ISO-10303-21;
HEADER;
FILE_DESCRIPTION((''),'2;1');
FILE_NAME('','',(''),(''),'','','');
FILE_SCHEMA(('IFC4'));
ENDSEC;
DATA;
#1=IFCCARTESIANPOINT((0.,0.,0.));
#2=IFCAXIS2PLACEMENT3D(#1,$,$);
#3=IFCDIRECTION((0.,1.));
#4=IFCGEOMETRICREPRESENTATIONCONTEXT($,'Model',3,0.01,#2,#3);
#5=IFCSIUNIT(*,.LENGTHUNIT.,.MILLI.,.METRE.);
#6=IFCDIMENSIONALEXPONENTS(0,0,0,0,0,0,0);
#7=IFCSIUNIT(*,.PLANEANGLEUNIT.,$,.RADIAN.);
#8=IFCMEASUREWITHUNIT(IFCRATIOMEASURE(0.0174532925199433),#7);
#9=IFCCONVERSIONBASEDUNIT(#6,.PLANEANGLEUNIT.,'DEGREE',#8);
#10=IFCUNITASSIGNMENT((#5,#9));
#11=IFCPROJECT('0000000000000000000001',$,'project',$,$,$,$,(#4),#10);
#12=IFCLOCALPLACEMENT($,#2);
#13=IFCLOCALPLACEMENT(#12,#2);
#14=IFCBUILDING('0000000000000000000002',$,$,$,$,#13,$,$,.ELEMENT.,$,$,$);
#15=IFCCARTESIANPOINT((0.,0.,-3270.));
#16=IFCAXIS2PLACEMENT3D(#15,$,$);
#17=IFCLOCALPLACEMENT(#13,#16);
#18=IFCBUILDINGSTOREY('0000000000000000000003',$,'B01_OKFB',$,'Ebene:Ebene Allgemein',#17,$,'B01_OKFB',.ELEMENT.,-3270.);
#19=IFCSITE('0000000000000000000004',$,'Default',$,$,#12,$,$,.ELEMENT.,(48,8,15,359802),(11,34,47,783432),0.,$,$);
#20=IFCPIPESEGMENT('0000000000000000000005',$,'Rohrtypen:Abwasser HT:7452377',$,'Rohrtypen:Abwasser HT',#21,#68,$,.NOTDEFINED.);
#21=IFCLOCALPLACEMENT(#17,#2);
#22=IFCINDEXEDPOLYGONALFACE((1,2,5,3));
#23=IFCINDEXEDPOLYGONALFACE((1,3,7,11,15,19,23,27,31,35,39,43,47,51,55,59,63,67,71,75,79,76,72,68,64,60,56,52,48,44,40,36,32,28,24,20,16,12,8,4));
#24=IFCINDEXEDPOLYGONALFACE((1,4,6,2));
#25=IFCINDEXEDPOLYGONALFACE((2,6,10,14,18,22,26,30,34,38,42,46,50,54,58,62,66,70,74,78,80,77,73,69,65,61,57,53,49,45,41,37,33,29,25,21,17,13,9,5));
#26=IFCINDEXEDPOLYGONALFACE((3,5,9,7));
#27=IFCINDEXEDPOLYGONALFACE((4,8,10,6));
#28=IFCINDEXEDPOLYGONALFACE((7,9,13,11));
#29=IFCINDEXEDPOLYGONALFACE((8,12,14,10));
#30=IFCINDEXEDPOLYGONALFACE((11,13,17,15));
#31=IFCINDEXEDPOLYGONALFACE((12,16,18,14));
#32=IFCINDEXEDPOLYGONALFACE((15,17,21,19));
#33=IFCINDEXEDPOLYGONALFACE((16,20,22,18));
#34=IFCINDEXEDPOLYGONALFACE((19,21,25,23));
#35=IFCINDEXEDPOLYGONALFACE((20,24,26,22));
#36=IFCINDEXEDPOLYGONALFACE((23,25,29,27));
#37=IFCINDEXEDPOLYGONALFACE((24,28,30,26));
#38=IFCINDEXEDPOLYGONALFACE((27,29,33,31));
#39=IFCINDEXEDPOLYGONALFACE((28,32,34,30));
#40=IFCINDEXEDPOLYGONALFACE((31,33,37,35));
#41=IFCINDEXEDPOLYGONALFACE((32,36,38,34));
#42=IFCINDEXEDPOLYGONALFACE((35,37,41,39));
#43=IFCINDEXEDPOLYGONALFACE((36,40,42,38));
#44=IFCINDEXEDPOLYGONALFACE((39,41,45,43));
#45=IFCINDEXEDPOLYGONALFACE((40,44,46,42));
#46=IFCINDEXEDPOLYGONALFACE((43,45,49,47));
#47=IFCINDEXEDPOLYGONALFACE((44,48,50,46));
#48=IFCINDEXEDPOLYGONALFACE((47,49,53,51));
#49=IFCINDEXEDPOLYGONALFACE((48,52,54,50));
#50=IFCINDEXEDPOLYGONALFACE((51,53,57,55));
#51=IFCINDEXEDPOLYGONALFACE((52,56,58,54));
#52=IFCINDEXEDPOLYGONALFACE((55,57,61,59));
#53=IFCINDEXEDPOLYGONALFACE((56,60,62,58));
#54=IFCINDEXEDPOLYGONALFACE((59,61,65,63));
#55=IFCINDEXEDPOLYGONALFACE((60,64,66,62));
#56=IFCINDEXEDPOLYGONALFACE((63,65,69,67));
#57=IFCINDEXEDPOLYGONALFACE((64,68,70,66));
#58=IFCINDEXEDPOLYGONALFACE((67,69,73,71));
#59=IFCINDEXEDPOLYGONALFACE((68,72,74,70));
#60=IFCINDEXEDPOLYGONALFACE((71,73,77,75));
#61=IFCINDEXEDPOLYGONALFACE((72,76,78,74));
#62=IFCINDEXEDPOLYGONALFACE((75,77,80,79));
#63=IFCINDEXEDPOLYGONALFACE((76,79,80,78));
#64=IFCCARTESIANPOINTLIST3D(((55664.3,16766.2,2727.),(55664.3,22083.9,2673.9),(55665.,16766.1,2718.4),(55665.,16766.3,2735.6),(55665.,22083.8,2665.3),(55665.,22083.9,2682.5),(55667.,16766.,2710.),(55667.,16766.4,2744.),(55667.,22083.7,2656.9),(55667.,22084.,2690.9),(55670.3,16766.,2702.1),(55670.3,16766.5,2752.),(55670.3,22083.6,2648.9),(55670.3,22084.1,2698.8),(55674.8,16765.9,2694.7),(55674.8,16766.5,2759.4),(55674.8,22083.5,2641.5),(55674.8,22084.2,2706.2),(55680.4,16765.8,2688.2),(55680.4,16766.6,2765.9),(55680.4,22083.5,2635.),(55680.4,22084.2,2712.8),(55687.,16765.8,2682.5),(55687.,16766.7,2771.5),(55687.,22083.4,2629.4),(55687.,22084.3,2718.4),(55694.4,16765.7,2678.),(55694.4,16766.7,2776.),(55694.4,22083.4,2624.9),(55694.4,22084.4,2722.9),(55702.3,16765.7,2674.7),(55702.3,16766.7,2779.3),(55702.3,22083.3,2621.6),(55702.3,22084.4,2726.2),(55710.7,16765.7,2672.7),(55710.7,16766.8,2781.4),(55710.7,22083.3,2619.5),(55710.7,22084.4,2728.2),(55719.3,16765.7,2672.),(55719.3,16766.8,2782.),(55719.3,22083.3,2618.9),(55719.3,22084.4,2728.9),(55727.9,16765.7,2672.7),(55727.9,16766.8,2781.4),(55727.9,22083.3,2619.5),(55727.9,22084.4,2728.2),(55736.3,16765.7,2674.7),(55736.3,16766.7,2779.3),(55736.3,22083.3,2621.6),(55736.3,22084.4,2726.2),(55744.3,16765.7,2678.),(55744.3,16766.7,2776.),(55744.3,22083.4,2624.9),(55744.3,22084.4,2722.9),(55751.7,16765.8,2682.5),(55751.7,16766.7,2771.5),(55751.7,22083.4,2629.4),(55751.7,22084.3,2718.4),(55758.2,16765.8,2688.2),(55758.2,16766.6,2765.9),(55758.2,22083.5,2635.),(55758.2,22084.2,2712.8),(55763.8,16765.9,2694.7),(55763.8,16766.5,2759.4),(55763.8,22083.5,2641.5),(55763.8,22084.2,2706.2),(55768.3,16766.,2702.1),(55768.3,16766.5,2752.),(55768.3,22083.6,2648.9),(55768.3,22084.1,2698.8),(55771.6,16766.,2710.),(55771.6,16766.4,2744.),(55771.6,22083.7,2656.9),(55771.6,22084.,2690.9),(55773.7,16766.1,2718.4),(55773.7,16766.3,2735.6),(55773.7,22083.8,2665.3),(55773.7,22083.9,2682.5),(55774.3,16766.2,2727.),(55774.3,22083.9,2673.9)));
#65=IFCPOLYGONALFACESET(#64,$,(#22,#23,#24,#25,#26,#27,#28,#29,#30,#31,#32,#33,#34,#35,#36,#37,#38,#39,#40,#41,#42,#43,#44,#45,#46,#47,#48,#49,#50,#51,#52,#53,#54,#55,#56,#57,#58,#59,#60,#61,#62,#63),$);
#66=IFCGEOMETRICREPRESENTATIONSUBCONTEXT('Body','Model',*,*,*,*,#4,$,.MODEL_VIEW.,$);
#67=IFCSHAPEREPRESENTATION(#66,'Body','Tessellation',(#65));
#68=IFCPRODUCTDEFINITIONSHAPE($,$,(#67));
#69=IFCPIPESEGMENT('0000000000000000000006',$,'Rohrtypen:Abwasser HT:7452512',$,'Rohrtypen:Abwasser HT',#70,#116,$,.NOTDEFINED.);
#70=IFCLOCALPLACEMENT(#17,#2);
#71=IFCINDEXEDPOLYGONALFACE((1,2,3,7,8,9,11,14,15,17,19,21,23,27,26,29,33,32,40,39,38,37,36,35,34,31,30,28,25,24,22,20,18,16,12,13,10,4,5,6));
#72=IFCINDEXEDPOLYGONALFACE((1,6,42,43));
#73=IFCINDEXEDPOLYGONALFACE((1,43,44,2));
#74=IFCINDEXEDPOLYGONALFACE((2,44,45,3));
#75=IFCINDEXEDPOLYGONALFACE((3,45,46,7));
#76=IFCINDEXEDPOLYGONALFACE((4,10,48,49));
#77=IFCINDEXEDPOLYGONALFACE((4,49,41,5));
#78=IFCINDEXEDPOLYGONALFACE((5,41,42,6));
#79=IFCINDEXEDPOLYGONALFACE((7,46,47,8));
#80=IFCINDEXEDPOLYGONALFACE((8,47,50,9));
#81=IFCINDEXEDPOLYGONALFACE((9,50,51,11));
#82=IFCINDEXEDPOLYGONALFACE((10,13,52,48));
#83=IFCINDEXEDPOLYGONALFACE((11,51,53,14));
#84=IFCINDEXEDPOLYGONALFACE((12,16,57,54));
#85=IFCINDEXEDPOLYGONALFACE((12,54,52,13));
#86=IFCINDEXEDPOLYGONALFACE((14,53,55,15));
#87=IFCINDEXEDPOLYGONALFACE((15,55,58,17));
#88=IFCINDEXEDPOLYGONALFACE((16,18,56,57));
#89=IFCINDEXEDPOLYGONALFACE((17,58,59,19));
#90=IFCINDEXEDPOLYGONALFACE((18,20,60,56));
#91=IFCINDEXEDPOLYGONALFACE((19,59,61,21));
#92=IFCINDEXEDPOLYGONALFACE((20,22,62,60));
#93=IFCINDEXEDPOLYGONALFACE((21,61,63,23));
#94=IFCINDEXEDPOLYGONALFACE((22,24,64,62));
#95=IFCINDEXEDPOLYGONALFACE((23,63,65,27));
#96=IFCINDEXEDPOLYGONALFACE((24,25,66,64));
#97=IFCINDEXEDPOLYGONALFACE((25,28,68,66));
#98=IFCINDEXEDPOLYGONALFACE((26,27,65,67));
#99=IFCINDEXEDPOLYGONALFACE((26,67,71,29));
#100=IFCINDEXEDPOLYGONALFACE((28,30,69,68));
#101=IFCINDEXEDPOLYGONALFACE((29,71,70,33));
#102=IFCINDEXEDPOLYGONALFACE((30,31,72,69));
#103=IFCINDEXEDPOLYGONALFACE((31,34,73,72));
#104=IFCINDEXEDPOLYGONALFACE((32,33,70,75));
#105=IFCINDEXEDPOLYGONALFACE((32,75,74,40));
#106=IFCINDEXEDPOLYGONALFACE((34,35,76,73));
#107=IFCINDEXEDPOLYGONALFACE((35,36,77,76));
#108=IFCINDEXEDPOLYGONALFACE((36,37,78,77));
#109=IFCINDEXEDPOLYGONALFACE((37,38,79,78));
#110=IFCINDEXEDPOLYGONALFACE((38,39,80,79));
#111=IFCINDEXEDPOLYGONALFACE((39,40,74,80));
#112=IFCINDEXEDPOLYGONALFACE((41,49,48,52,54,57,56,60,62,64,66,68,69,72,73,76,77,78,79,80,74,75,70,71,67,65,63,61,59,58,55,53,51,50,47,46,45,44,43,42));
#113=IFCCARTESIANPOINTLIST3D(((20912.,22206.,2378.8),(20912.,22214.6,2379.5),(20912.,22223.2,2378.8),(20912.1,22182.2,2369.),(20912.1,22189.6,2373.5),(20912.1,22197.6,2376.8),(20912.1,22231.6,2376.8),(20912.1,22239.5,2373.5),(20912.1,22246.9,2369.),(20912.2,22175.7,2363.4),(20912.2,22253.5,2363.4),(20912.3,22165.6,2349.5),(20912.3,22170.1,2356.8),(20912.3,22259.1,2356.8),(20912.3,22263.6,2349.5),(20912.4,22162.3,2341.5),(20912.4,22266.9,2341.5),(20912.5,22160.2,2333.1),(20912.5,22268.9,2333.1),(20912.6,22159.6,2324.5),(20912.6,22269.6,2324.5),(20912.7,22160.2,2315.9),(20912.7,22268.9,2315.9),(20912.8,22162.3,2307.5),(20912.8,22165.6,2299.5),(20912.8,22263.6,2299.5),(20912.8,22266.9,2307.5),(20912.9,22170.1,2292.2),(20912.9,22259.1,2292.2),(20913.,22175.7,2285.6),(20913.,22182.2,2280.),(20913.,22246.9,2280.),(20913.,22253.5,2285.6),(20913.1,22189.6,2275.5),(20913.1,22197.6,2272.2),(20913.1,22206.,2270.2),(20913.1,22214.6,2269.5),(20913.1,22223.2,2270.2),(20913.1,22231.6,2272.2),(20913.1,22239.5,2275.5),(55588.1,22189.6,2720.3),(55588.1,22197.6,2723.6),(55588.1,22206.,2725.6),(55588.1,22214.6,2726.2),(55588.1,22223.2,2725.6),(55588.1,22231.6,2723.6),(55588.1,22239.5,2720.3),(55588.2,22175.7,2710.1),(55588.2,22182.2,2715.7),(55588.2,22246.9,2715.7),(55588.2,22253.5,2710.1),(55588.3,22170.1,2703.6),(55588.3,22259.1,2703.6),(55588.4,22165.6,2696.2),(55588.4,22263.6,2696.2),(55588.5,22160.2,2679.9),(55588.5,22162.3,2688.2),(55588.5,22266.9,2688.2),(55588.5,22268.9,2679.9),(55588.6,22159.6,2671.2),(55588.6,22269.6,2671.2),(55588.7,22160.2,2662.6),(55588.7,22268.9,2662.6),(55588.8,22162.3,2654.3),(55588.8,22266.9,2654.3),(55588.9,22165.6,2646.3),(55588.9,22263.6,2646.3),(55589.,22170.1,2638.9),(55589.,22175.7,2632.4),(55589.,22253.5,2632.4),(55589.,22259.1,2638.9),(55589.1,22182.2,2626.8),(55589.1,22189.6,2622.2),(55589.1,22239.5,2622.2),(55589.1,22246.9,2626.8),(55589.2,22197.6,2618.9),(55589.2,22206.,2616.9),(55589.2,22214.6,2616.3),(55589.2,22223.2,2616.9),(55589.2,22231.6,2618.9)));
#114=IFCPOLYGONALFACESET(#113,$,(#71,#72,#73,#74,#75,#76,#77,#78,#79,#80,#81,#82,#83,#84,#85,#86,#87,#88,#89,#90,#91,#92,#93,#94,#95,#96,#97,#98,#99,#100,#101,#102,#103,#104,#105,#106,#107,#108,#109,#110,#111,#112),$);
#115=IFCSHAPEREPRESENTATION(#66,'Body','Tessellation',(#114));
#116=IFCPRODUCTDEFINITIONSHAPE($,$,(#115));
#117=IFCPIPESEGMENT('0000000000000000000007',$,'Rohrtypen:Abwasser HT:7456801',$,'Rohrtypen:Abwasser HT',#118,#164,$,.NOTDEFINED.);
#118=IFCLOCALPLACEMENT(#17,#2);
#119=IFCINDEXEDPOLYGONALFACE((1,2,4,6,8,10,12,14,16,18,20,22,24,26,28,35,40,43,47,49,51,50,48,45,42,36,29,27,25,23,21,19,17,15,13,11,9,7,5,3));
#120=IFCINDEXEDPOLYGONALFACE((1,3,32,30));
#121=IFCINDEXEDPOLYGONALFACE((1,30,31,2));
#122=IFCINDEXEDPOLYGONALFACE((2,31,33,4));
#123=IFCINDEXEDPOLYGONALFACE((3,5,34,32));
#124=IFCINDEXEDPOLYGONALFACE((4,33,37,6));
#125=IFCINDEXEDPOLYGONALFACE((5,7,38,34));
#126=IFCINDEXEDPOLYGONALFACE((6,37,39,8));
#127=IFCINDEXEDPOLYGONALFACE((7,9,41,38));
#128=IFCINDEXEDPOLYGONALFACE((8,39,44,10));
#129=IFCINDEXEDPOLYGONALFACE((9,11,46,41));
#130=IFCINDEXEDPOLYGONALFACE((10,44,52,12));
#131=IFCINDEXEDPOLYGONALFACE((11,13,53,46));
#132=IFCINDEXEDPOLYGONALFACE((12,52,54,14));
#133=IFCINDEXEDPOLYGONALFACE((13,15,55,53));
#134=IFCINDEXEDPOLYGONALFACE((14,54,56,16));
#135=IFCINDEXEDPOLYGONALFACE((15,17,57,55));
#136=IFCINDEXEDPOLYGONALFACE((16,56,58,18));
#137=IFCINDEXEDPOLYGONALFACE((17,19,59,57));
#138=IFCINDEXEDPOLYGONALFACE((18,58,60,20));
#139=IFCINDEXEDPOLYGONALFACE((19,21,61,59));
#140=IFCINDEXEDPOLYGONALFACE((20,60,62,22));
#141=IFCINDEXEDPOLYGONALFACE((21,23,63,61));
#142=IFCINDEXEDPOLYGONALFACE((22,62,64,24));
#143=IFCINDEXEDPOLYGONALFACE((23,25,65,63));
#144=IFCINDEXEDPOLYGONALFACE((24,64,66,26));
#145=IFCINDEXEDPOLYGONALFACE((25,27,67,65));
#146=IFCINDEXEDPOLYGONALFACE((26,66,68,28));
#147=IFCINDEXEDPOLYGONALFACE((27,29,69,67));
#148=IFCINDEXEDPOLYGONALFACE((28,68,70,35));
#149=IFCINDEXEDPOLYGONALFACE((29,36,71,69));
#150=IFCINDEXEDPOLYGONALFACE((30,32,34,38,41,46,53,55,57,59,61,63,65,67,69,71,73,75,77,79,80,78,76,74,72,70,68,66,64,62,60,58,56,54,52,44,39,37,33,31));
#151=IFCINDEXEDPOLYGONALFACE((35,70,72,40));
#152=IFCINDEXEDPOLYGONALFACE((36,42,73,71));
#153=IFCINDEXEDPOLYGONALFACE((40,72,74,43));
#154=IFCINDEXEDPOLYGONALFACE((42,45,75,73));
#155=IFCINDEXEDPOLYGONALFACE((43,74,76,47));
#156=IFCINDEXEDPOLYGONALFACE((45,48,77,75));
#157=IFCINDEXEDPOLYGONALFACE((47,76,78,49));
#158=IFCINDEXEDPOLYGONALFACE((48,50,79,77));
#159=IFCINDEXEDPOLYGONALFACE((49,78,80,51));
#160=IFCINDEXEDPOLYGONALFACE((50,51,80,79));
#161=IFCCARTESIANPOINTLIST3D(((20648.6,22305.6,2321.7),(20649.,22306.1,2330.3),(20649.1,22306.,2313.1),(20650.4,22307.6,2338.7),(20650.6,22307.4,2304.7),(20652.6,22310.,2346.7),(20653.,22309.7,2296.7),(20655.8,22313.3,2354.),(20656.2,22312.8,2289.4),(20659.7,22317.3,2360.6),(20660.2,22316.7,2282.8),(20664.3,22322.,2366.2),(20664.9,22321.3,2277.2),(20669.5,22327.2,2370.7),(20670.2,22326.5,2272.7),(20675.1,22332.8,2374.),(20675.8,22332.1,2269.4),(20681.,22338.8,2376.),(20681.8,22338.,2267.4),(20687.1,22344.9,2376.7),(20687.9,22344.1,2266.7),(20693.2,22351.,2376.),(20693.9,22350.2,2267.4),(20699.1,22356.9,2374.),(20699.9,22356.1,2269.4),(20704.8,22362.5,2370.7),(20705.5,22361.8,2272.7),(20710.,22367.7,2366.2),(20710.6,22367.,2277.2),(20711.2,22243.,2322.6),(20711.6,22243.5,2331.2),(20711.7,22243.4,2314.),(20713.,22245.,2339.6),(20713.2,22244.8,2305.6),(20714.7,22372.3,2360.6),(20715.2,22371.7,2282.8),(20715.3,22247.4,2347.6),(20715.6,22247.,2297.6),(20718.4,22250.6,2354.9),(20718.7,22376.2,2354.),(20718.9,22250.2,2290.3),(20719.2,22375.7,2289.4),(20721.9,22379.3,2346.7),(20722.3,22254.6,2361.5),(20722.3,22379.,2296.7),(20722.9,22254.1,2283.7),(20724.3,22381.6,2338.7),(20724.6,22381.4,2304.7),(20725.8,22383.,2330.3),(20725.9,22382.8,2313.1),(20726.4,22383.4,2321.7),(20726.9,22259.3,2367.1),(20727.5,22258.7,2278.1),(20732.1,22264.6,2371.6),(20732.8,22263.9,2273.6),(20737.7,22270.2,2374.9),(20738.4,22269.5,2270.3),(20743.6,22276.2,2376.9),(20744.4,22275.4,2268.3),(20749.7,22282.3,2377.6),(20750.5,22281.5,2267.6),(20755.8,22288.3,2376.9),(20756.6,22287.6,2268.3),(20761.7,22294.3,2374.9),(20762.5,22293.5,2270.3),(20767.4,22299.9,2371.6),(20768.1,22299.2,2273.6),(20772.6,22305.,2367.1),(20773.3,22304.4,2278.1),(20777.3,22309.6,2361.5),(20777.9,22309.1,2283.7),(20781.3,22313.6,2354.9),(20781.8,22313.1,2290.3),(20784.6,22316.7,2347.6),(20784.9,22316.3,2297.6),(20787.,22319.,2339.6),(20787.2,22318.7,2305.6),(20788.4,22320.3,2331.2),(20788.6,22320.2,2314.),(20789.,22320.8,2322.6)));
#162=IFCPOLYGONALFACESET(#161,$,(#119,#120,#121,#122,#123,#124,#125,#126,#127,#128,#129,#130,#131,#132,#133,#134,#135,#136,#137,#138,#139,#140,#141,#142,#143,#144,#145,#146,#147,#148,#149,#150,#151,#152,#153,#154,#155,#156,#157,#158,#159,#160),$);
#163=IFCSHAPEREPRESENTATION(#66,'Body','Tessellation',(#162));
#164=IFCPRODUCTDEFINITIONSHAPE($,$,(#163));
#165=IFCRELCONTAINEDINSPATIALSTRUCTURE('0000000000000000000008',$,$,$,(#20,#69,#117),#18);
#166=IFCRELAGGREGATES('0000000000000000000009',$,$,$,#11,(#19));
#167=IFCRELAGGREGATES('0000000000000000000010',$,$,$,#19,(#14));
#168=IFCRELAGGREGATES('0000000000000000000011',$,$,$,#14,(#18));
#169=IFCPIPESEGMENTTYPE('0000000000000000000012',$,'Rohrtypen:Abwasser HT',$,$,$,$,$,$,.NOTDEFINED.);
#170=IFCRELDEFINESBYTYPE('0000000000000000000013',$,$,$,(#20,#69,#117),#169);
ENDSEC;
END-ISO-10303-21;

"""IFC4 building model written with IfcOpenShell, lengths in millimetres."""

from ifc_helpers import new_model, entity, si_unit, converted_unit, direction, frame, origin, place, context, subcontext, project, spatial, indexed_curve, outline, extrude, type_object, element, save


model = new_model("IFC4")

# Units and contexts
model_context = context("Model", 3, precision=0.01, world=origin(), true_north=direction((0.0, 1.0)))
body_context = subcontext(model_context, "Body", "Model", "MODEL_VIEW")
ifc_project = project(units=[si_unit("LENGTHUNIT", "METRE", prefix="MILLI"), converted_unit("PLANEANGLEUNIT", "DEGREE", entity("IfcRatioMeasure", 0.0174532925199433), si_unit("PLANEANGLEUNIT", "RADIAN"), dimensions=[0, 0, 0, 0, 0, 0, 0])], contexts=[model_context])

# Site, building, storey
site_placement = place(None, origin())
site = spatial("IfcSite", under=ifc_project, at=site_placement, Name="Default", CompositionType="ELEMENT", RefLatitude=(48, 8, 15, 359802), RefLongitude=(11, 34, 47, 783432), RefElevation=0.0)
building_placement = place(site_placement, origin())
building = spatial("IfcBuilding", under=site, at=building_placement, CompositionType="ELEMENT")
storey_placement = place(building_placement, frame((0.0, 0.0, -3270.0)))
storey = spatial("IfcBuildingStorey", under=building, at=storey_placement, Name="B01_OKFB", ObjectType="Ebene:Ebene Allgemein", LongName="B01_OKFB", CompositionType="ELEMENT", Elevation=-3270.0)

# Pipe segments
pipe_segment_type_1 = type_object("IfcPipeSegmentType", Name="Rohrtypen:Abwasser HT", PredefinedType="NOTDEFINED")
pipe_segment_1_placement = place(storey_placement, origin())
element("IfcPipeSegment", 1, at=pipe_segment_1_placement, inside=storey, type_object=pipe_segment_type_1, Name="Rohrtypen:Abwasser HT:7452377", ObjectType="Rohrtypen:Abwasser HT", PredefinedType="NOTDEFINED", context=body_context, shape_type="SweptSolid", body=[
    extrude(outline(indexed_curve([(55.0, 0.0), (54.3, 8.6), (52.3, 17.0), (49.0, 25.0), (44.5, 32.3), (38.9, 38.9), (32.3, 44.5), (25.0, 49.0), (17.0, 52.3), (8.6, 54.3), (0.0, 55.0), (-8.6, 54.3), (-17.0, 52.3), (-25.0, 49.0), (-32.3, 44.5), (-38.9, 38.9), (-44.5, 32.3), (-49.0, 25.0), (-52.3, 17.0), (-54.3, 8.6), (-55.0, 0.0), (-54.3, -8.6), (-52.3, -17.0), (-49.0, -25.0), (-44.5, -32.3), (-38.9, -38.9), (-32.3, -44.5), (-25.0, -49.0), (-17.0, -52.3), (-8.6, -54.3), (0.0, -55.0), (8.6, -54.3), (17.0, -52.3), (25.0, -49.0), (32.3, -44.5), (38.9, -38.9), (44.5, -32.3), (49.0, -25.0), (52.3, -17.0), (54.3, -8.6), (55.0, 0.0)], self_intersect=False)), frame((55719.3, 22083.9, 2673.9), z_axis=(0.0, -0.99995, 0.01), x_axis=(-1.0, 0.0, 0.0)), (0.0, 0.0, 1.0), 5317.9),
])
pipe_segment_2_placement = place(storey_placement, origin())
element("IfcPipeSegment", 2, at=pipe_segment_2_placement, inside=storey, type_object=pipe_segment_type_1, Name="Rohrtypen:Abwasser HT:7452512", ObjectType="Rohrtypen:Abwasser HT", PredefinedType="NOTDEFINED", context=body_context, shape_type="SweptSolid", body=[
    extrude(outline(indexed_curve([(55.0, 0.0), (54.3, 8.6), (52.3, 17.0), (49.0, 25.0), (44.5, 32.3), (38.9, 38.9), (32.3, 44.5), (25.0, 49.0), (17.0, 52.3), (8.6, 54.3), (0.0, 55.0), (-8.6, 54.3), (-17.0, 52.3), (-25.0, 49.0), (-32.3, 44.5), (-38.9, 38.9), (-44.5, 32.3), (-49.0, 25.0), (-52.3, 17.0), (-54.3, 8.6), (-55.0, 0.0), (-54.3, -8.6), (-52.3, -17.0), (-49.0, -25.0), (-44.5, -32.3), (-38.9, -38.9), (-32.3, -44.5), (-25.0, -49.0), (-17.0, -52.3), (-8.6, -54.3), (0.0, -55.0), (8.6, -54.3), (17.0, -52.3), (25.0, -49.0), (32.3, -44.5), (38.9, -38.9), (44.5, -32.3), (49.0, -25.0), (52.3, -17.0), (54.3, -8.6), (55.0, 0.0)], self_intersect=False)), frame((20912.6, 22214.6, 2324.5), z_axis=(0.99995, 0.0, 0.01), x_axis=(0.0, 1.0, 0.0)), (0.0, 0.0, 1.0), 34677.8),
])
pipe_segment_3_placement = place(storey_placement, origin())
element("IfcPipeSegment", 3, at=pipe_segment_3_placement, inside=storey, type_object=pipe_segment_type_1, Name="Rohrtypen:Abwasser HT:7456801", ObjectType="Rohrtypen:Abwasser HT", PredefinedType="NOTDEFINED", context=body_context, shape_type="SweptSolid", body=[
    extrude(outline(indexed_curve([(55.0, 0.0), (54.3, 8.6), (52.3, 17.0), (49.0, 25.0), (44.5, 32.3), (38.9, 38.9), (32.3, 44.5), (25.0, 49.0), (17.0, 52.3), (8.6, 54.3), (0.0, 55.0), (-8.6, 54.3), (-17.0, 52.3), (-25.0, 49.0), (-32.3, 44.5), (-38.9, 38.9), (-44.5, 32.3), (-49.0, 25.0), (-52.3, 17.0), (-54.3, 8.6), (-55.0, 0.0), (-54.3, -8.6), (-52.3, -17.0), (-49.0, -25.0), (-44.5, -32.3), (-38.9, -38.9), (-32.3, -44.5), (-25.0, -49.0), (-17.0, -52.3), (-8.6, -54.3), (0.0, -55.0), (8.6, -54.3), (17.0, -52.3), (25.0, -49.0), (32.3, -44.5), (38.9, -38.9), (44.5, -32.3), (49.0, -25.0), (52.3, -17.0), (54.3, -8.6), (55.0, 0.0)], self_intersect=False)), frame((20687.5, 22344.5, 2321.7), z_axis=(0.707071, -0.707071, 0.01), x_axis=(0.707107, 0.707107, 0.0)), (0.0, 0.0, 1.0), 88.6),
])

save(model, "model.ifc")
